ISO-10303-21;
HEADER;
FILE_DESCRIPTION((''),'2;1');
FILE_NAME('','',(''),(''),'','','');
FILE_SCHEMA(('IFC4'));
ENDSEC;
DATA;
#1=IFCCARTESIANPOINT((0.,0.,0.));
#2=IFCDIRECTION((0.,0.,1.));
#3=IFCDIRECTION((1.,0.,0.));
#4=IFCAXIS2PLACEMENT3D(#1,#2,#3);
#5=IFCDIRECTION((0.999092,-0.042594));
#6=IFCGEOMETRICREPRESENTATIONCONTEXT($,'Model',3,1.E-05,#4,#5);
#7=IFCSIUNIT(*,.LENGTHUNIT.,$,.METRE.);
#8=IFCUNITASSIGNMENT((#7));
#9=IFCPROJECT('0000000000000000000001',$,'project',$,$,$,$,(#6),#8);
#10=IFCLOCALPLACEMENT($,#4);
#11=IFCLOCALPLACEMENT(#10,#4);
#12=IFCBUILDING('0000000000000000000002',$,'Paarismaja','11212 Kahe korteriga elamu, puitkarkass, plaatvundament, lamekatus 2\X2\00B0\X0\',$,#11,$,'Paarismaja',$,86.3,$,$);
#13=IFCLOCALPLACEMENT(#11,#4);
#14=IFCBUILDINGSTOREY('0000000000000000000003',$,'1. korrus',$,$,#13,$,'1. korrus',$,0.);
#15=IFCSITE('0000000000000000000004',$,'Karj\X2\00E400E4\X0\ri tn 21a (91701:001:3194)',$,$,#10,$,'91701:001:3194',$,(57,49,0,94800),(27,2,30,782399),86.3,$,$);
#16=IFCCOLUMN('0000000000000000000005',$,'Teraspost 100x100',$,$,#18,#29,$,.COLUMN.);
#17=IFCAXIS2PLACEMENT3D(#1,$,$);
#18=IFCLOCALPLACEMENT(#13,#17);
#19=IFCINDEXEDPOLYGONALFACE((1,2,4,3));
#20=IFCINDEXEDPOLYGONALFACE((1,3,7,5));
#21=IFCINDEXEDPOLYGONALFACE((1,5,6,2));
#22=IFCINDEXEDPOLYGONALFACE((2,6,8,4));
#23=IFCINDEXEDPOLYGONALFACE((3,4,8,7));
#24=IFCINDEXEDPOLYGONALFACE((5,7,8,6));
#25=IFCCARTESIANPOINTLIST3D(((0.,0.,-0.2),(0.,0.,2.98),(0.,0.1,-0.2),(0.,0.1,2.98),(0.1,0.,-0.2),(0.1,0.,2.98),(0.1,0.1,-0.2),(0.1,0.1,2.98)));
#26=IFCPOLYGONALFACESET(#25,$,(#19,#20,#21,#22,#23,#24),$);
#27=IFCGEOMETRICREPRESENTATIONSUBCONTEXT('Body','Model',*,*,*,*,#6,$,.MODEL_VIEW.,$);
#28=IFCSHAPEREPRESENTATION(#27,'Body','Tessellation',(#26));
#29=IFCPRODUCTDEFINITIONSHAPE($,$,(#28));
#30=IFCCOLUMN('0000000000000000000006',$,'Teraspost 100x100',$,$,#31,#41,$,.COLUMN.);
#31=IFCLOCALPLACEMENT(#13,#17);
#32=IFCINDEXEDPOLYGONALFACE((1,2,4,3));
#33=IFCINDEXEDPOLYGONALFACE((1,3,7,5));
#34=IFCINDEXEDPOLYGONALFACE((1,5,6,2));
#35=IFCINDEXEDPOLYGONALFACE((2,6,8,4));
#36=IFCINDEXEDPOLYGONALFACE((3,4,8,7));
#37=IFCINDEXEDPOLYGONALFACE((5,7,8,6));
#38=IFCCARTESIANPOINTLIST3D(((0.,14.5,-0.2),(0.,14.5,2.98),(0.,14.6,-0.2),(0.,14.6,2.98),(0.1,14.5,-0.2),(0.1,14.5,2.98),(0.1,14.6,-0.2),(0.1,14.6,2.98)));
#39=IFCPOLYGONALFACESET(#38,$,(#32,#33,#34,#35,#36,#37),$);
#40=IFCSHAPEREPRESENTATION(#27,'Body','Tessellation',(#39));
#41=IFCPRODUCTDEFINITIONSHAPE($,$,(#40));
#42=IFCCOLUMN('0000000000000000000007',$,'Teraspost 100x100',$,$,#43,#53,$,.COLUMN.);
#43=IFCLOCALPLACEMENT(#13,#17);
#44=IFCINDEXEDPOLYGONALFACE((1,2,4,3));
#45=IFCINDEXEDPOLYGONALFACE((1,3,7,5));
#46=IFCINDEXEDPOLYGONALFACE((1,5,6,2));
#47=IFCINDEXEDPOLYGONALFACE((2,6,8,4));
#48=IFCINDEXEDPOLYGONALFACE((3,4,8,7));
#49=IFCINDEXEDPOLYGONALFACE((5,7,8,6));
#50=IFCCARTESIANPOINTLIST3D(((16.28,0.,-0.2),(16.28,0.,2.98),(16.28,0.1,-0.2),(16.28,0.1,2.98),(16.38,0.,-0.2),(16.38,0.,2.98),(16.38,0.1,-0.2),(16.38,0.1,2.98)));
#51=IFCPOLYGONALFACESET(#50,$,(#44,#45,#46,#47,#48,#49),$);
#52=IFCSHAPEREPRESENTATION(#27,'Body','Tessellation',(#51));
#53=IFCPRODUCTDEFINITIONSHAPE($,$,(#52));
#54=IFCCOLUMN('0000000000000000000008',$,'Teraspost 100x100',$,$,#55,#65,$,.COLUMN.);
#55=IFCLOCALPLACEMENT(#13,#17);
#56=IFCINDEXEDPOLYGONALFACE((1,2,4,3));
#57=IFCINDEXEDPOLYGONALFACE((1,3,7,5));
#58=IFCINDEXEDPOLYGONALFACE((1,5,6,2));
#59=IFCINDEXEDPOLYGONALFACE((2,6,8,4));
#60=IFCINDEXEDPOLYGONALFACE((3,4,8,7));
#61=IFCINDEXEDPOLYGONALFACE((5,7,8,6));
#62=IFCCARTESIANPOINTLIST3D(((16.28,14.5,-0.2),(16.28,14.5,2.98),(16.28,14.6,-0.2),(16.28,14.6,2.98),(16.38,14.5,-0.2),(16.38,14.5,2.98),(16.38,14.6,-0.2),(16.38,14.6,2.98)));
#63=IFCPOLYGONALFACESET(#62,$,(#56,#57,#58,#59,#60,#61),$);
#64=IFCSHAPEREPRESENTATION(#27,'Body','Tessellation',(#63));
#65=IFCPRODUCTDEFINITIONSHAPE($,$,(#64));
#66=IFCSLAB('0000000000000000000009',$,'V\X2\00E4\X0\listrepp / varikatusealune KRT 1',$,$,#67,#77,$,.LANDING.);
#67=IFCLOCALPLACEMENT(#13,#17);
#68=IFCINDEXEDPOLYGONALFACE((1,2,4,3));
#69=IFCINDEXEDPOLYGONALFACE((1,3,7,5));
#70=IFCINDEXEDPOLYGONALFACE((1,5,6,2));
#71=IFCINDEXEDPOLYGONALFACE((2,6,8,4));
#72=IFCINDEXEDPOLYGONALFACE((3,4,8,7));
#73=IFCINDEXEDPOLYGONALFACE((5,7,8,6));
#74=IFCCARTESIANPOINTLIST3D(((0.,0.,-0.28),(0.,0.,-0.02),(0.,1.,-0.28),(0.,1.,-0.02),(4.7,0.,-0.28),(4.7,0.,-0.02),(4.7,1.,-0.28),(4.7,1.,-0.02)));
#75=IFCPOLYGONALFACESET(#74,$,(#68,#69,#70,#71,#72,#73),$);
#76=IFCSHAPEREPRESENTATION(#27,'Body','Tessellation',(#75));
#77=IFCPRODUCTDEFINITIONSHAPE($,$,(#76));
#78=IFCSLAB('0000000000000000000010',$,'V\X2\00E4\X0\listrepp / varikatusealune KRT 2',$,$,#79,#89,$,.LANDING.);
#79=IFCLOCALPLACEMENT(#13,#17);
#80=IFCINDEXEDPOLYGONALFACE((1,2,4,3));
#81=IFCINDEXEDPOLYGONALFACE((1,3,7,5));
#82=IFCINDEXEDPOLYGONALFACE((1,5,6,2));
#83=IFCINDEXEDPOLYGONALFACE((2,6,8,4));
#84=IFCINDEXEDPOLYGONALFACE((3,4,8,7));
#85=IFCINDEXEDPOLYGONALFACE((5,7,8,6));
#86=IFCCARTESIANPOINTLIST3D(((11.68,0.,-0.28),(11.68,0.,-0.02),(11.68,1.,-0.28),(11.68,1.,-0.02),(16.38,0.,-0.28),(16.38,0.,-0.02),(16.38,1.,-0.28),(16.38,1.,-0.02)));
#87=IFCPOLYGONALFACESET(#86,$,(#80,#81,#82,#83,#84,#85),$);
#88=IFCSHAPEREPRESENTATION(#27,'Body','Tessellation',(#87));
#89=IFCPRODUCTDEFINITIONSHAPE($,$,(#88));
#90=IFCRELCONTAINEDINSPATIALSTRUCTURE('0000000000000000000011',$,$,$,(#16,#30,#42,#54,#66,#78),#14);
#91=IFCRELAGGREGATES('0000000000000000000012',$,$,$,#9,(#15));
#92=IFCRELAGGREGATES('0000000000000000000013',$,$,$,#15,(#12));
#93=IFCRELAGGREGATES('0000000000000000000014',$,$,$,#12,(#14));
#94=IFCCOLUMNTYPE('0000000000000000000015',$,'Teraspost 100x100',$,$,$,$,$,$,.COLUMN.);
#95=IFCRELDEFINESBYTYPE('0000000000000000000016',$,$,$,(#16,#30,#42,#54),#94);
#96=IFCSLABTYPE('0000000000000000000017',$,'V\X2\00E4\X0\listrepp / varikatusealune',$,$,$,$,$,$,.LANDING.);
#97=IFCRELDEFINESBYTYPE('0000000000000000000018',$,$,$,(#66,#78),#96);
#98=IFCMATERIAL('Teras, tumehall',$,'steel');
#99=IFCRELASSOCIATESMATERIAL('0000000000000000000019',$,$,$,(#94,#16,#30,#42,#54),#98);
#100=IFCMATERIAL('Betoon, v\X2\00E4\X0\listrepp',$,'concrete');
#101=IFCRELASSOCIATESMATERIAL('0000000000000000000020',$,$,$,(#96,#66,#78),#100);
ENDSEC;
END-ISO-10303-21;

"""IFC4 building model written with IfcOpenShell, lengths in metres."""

from ifc_helpers import new_model, si_unit, direction, frame, origin_with_axes, place, context, subcontext, project, spatial, indexed_curve, outline, extrude, material, type_object, element, save


model = new_model("IFC4")

# Units and contexts
model_context = context("Model", 3, precision=1e-05, world=origin_with_axes(), true_north=direction((0.999092, -0.042594)))
body_context = subcontext(model_context, "Body", "Model", "MODEL_VIEW")
ifc_project = project(units=[si_unit("LENGTHUNIT", "METRE")], contexts=[model_context])

# Site, building, storey
site_placement = place(None, origin_with_axes())
site = spatial("IfcSite", under=ifc_project, at=site_placement, Name="Karjääri tn 21a (91701:001:3194)", LongName="91701:001:3194", RefLatitude=(57, 49, 0, 94800), RefLongitude=(27, 2, 30, 782399), RefElevation=86.3)
building_placement = place(site_placement, origin_with_axes())
building = spatial("IfcBuilding", under=site, at=building_placement, Name="Paarismaja", Description="11212 Kahe korteriga elamu, puitkarkass, plaatvundament, lamekatus 2°", LongName="Paarismaja", ElevationOfRefHeight=86.3)
storey_placement = place(building_placement, origin_with_axes())
storey = spatial("IfcBuildingStorey", under=building, at=storey_placement, Name="1. korrus", LongName="1. korrus", Elevation=0.0)

# Columns
ifc_material_1 = material(Name="Teras, tumehall", Category="steel")
column_type = type_object("IfcColumnType", Name="Teraspost 100x100", PredefinedType="COLUMN", material=ifc_material_1)
column_1_placement = place(storey_placement, origin_with_axes())
element("IfcColumn", 1, at=column_1_placement, inside=storey, type_object=column_type, material=ifc_material_1, Name="Teraspost 100x100", PredefinedType="COLUMN", context=body_context, shape_type="SweptSolid", body=[
    extrude(outline(indexed_curve([(0.0, 0.0), (0.1, 0.0), (0.1, 0.1), (0.0, 0.1), (0.0, 0.0)], self_intersect=False)), frame((0.0, 0.0, -0.2), z_axis=(0.0, 0.0, 1.0), x_axis=(1.0, 0.0, 0.0)), (0.0, 0.0, 1.0), 3.18),
])
column_2_placement = place(storey_placement, origin_with_axes())
element("IfcColumn", 2, at=column_2_placement, inside=storey, type_object=column_type, material=ifc_material_1, Name="Teraspost 100x100", PredefinedType="COLUMN", context=body_context, shape_type="SweptSolid", body=[
    extrude(outline(indexed_curve([(0.0, 14.5), (0.1, 14.5), (0.1, 14.6), (0.0, 14.6), (0.0, 14.5)], self_intersect=False)), frame((0.0, 0.0, -0.2), z_axis=(0.0, 0.0, 1.0), x_axis=(1.0, 0.0, 0.0)), (0.0, 0.0, 1.0), 3.18),
])
column_3_placement = place(storey_placement, origin_with_axes())
element("IfcColumn", 3, at=column_3_placement, inside=storey, type_object=column_type, material=ifc_material_1, Name="Teraspost 100x100", PredefinedType="COLUMN", context=body_context, shape_type="SweptSolid", body=[
    extrude(outline(indexed_curve([(16.28, 0.0), (16.38, 0.0), (16.38, 0.1), (16.28, 0.1), (16.28, 0.0)], self_intersect=False)), frame((0.0, 0.0, -0.2), z_axis=(0.0, 0.0, 1.0), x_axis=(1.0, 0.0, 0.0)), (0.0, 0.0, 1.0), 3.18),
])
column_4_placement = place(storey_placement, origin_with_axes())
element("IfcColumn", 4, at=column_4_placement, inside=storey, type_object=column_type, material=ifc_material_1, Name="Teraspost 100x100", PredefinedType="COLUMN", context=body_context, shape_type="SweptSolid", body=[
    extrude(outline(indexed_curve([(16.28, 14.5), (16.38, 14.5), (16.38, 14.6), (16.28, 14.6), (16.28, 14.5)], self_intersect=False)), frame((0.0, 0.0, -0.2), z_axis=(0.0, 0.0, 1.0), x_axis=(1.0, 0.0, 0.0)), (0.0, 0.0, 1.0), 3.18),
])

# Slabs
ifc_material_2 = material(Name="Betoon, välistrepp", Category="concrete")
slab_type_1 = type_object("IfcSlabType", Name="Välistrepp / varikatusealune", PredefinedType="LANDING", material=ifc_material_2)
slab_1_placement = place(storey_placement, origin_with_axes())
element("IfcSlab", 5, at=slab_1_placement, inside=storey, type_object=slab_type_1, material=ifc_material_2, Name="Välistrepp / varikatusealune KRT 1", PredefinedType="LANDING", context=body_context, shape_type="SweptSolid", body=[
    extrude(outline(indexed_curve([(4.7, 0.0), (0.0, 0.0), (0.0, 1.0), (4.7, 1.0), (4.7, 0.0)], self_intersect=False)), frame((0.0, 0.0, -0.28), z_axis=(0.0, 0.0, 1.0), x_axis=(1.0, 0.0, 0.0)), (0.0, 0.0, 1.0), 0.26),
])
slab_2_placement = place(storey_placement, origin_with_axes())
element("IfcSlab", 6, at=slab_2_placement, inside=storey, type_object=slab_type_1, material=ifc_material_2, Name="Välistrepp / varikatusealune KRT 2", PredefinedType="LANDING", context=body_context, shape_type="SweptSolid", body=[
    extrude(outline(indexed_curve([(16.38, 0.0), (11.68, 0.0), (11.68, 1.0), (16.38, 1.0), (16.38, 0.0)], self_intersect=False)), frame((0.0, 0.0, -0.28), z_axis=(0.0, 0.0, 1.0), x_axis=(1.0, 0.0, 0.0)), (0.0, 0.0, 1.0), 0.26),
])

save(model, "model.ifc")
